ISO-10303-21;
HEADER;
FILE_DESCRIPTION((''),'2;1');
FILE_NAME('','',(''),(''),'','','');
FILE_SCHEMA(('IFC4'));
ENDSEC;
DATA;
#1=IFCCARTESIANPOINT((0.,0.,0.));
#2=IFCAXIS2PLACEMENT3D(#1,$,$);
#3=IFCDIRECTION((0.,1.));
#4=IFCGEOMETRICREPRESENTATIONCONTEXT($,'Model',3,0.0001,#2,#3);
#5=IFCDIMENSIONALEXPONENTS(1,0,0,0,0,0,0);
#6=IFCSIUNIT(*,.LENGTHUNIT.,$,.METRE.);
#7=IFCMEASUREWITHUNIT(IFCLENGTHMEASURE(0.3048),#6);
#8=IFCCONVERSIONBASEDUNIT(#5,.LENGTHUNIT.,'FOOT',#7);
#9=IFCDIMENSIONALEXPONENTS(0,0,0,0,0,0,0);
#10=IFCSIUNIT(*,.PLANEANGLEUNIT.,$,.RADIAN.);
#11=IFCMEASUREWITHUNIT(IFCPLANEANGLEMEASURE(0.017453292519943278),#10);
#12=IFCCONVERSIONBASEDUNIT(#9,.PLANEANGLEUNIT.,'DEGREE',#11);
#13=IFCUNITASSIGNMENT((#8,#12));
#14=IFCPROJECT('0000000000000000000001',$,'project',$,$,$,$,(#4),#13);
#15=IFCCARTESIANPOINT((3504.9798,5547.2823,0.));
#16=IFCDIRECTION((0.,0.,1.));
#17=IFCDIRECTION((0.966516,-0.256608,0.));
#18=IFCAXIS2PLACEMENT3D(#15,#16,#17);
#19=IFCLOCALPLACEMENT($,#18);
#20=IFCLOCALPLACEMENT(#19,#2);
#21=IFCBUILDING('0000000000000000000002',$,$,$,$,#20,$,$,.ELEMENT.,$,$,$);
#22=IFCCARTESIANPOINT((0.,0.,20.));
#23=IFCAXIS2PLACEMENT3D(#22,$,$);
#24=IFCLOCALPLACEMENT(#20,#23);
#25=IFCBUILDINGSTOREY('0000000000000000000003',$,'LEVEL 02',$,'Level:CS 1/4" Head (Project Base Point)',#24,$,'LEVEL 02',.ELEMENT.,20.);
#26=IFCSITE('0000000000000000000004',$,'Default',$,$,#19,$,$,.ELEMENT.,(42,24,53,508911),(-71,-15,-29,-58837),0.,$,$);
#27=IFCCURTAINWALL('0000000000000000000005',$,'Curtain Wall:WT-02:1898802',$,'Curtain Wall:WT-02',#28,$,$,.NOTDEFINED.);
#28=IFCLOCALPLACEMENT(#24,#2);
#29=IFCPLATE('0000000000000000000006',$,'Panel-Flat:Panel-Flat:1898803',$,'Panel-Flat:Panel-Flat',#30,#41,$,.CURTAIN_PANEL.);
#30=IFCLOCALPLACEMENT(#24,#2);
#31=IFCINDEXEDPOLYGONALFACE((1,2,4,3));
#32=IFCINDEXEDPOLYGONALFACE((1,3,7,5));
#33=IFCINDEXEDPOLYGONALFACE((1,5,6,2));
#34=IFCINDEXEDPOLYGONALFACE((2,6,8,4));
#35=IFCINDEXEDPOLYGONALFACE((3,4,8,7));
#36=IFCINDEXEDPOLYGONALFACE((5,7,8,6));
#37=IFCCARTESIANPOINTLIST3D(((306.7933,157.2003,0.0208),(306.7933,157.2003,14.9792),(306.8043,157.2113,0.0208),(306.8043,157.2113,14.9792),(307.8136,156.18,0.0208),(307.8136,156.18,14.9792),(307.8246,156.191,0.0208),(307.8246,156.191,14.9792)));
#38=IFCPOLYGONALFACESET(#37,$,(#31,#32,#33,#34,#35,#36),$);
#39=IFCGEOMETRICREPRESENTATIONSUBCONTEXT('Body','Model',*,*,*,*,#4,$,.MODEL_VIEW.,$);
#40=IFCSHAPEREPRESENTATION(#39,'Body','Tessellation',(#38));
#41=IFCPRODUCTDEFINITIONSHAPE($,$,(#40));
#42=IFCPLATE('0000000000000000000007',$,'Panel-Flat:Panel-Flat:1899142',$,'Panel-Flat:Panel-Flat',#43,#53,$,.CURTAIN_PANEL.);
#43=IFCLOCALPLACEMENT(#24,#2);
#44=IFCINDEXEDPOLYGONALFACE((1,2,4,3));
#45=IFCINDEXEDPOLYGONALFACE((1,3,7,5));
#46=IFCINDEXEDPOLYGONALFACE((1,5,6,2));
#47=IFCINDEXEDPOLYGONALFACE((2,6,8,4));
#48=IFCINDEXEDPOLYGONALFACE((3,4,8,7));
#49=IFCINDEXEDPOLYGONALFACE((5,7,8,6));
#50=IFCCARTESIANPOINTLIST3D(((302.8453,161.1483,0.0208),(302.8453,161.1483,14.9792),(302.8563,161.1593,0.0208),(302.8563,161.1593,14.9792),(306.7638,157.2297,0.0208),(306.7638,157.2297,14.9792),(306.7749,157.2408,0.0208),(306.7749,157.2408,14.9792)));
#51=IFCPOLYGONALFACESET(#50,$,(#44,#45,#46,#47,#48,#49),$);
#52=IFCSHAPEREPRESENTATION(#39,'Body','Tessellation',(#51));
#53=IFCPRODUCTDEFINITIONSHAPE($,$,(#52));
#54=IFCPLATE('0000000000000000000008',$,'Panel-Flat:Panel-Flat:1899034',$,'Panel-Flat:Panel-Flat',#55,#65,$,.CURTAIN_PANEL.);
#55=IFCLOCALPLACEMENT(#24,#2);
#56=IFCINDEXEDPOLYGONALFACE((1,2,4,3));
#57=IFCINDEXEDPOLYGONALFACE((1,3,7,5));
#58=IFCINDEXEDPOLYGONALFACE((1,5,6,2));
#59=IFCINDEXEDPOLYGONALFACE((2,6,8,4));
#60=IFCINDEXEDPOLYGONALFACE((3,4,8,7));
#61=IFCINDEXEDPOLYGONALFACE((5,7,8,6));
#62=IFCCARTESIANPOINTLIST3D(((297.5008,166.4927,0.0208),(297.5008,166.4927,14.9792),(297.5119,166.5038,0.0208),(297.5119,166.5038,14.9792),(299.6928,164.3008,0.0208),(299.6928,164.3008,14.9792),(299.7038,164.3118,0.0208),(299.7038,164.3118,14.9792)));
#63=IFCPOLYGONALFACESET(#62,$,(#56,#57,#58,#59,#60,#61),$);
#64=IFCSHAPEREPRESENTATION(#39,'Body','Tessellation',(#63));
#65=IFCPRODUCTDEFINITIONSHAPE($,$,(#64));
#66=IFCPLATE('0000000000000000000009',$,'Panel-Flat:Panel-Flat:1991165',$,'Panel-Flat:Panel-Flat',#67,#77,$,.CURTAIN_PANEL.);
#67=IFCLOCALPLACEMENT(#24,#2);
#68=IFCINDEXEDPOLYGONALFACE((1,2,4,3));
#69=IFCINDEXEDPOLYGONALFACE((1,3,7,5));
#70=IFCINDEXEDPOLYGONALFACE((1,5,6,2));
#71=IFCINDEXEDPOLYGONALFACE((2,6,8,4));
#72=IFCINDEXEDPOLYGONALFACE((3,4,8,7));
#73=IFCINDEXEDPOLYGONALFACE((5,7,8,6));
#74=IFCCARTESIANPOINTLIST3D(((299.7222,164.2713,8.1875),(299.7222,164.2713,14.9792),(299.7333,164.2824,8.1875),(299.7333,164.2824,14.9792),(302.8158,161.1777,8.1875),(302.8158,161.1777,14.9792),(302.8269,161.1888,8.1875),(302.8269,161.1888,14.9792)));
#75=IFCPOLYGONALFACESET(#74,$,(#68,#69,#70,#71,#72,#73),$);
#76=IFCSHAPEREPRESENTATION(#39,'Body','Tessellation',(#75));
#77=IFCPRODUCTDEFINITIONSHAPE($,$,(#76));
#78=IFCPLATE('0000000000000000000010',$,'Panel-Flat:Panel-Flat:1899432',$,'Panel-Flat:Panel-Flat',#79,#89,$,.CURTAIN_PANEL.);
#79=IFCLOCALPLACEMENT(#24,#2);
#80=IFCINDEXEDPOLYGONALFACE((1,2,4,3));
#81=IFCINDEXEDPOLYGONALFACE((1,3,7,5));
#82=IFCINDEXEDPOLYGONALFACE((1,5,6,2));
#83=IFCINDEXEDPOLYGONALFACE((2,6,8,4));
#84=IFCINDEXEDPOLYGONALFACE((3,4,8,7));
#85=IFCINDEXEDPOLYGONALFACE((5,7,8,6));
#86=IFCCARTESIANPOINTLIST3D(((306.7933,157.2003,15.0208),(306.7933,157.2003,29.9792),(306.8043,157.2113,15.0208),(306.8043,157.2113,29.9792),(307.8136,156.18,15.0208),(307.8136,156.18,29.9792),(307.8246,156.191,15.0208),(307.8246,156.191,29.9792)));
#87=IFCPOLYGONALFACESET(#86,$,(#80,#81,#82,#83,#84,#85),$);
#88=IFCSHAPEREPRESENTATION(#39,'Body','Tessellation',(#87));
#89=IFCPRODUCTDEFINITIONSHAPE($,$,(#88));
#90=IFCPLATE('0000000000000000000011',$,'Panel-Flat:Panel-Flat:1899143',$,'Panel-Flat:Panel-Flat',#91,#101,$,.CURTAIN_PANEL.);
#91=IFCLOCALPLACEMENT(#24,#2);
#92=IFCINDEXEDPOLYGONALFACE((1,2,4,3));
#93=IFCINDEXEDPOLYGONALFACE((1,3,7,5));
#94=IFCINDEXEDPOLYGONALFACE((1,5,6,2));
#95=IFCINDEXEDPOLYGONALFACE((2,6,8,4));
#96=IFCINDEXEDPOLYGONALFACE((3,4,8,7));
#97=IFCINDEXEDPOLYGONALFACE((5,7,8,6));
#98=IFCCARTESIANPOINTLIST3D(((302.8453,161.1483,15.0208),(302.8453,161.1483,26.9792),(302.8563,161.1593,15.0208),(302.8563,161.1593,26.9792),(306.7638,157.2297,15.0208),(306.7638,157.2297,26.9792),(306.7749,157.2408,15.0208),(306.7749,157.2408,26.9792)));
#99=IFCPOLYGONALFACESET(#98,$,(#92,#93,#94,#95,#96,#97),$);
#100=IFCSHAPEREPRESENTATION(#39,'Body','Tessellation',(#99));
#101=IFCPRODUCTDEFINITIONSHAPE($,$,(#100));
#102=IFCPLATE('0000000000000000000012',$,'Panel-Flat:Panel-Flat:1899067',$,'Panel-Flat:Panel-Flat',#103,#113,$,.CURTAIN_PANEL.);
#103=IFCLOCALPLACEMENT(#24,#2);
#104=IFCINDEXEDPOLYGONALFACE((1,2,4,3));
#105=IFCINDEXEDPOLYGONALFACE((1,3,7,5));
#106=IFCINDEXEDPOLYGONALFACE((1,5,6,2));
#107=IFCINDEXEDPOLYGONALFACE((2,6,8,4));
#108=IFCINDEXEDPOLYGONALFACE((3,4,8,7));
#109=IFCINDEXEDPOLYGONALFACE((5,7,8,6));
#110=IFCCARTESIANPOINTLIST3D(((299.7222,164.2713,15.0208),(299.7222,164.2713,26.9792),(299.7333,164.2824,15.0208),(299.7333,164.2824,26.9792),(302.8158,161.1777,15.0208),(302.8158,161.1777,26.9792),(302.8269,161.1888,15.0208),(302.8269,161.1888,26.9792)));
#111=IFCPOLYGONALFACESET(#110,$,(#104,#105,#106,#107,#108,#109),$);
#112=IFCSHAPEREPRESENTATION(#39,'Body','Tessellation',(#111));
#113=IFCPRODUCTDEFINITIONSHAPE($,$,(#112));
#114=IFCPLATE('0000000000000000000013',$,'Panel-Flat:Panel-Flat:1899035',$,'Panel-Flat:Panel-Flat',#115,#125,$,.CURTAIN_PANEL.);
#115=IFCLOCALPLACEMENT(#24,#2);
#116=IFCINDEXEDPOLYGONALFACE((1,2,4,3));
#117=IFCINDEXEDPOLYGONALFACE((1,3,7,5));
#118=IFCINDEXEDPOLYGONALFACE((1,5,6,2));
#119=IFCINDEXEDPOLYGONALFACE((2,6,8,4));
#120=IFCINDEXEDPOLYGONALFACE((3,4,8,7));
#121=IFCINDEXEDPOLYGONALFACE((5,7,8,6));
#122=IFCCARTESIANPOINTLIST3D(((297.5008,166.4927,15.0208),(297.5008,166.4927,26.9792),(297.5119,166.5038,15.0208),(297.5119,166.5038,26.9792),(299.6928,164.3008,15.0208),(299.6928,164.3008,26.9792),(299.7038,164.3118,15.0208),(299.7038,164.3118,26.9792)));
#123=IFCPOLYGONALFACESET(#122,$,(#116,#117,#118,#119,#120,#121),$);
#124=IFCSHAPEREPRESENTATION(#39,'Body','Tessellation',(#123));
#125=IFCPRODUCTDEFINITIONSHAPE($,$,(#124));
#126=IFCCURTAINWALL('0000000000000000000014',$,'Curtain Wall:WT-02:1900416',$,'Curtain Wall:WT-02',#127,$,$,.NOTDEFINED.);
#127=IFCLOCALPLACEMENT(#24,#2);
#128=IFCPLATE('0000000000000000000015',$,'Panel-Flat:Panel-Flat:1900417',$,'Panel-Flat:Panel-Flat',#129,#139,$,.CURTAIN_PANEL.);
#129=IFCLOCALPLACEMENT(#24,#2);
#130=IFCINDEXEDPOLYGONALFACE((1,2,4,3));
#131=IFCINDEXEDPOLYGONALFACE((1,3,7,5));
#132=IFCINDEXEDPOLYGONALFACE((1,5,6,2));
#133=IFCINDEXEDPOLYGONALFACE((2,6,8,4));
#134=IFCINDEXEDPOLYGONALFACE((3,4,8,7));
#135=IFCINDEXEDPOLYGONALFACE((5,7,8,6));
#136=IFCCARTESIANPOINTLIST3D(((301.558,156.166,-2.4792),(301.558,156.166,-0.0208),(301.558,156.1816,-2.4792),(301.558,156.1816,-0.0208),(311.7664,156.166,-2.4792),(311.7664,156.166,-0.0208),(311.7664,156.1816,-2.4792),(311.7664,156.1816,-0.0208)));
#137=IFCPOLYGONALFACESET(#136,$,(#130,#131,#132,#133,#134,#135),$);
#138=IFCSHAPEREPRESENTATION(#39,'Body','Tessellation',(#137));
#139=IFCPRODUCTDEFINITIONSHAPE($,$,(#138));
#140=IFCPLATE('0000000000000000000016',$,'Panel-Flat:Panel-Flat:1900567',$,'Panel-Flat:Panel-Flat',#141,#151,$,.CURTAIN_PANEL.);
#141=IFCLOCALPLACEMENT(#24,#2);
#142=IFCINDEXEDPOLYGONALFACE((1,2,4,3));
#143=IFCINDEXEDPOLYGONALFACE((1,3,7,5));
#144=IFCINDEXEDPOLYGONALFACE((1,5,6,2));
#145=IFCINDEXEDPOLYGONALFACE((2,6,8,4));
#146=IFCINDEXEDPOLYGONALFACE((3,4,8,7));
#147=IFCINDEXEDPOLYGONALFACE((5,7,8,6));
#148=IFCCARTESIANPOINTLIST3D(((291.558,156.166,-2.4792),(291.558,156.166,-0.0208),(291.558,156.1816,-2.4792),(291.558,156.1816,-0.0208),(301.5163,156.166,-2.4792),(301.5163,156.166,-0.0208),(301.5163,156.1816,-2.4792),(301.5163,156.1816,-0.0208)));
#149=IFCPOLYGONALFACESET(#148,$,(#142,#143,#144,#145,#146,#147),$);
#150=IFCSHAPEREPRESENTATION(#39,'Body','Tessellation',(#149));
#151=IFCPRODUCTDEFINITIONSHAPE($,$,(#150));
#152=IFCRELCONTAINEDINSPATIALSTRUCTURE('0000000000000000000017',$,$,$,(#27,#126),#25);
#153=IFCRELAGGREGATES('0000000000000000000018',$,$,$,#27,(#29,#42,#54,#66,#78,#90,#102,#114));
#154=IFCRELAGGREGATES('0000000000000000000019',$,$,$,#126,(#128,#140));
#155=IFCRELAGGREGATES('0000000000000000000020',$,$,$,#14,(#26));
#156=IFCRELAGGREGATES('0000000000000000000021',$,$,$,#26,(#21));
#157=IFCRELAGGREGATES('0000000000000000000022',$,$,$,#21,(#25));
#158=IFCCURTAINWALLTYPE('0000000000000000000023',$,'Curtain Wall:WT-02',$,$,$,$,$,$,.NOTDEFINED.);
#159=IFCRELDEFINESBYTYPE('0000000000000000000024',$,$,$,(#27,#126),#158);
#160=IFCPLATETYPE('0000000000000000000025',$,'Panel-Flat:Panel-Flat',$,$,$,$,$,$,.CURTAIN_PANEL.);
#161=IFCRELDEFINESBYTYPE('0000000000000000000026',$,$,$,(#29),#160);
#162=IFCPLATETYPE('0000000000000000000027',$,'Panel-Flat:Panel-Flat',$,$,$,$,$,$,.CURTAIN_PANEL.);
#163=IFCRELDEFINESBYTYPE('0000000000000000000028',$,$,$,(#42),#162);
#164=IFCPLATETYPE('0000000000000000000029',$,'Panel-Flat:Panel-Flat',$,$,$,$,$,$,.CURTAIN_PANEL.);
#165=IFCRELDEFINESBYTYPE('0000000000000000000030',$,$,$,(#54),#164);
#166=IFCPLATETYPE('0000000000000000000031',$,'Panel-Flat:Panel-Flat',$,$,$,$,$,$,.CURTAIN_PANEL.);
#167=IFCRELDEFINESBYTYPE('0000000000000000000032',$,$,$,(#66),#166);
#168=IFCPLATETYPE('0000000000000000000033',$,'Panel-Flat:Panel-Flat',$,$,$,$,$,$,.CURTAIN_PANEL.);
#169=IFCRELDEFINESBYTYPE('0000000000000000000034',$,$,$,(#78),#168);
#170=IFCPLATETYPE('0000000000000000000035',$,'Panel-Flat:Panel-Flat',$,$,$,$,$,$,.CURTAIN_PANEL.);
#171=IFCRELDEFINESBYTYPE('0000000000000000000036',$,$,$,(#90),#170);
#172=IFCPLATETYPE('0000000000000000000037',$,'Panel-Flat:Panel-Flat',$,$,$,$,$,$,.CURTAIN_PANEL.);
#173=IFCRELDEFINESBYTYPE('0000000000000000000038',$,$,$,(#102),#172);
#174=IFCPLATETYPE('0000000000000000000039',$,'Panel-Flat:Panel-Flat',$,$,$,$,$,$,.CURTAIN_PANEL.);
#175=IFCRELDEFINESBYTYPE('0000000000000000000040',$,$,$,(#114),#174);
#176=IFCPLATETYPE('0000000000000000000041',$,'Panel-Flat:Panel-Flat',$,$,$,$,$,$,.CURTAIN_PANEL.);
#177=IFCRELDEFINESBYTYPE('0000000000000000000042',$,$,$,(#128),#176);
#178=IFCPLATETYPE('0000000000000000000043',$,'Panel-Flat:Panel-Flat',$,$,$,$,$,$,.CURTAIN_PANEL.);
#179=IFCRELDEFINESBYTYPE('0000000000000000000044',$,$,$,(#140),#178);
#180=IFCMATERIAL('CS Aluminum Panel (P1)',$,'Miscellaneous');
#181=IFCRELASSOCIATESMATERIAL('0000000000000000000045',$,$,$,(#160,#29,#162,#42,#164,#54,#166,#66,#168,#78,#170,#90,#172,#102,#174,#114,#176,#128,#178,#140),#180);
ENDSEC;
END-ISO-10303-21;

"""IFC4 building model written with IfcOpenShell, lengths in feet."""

from ifc_helpers import new_model, entity, si_unit, converted_unit, direction, frame, origin, place, context, subcontext, project, spatial, indexed_curve, outline, extrude, source, transform, mapped, material, type_object, type_shapes, element, aggregate, save


model = new_model("IFC4")

# Units and contexts
model_context = context("Model", 3, precision=0.0001, world=origin(), true_north=direction((0.0, 1.0)))
body_context = subcontext(model_context, "Body", "Model", "MODEL_VIEW")
ifc_project = project(units=[converted_unit("LENGTHUNIT", "FOOT", entity("IfcLengthMeasure", 0.3048), si_unit("LENGTHUNIT", "METRE"), dimensions=[1, 0, 0, 0, 0, 0, 0]), converted_unit("PLANEANGLEUNIT", "DEGREE", entity("IfcPlaneAngleMeasure", 0.017453292519943278), si_unit("PLANEANGLEUNIT", "RADIAN"), dimensions=[0, 0, 0, 0, 0, 0, 0])], contexts=[model_context])

# Site, building, storey
site_placement = place(None, frame((3504.9798, 5547.2823, 0.0), z_axis=(0.0, 0.0, 1.0), x_axis=(0.966516, -0.256608, 0.0)))
site = spatial("IfcSite", under=ifc_project, at=site_placement, Name="Default", CompositionType="ELEMENT", RefLatitude=(42, 24, 53, 508911), RefLongitude=(-71, -15, -29, -58837), RefElevation=0.0)
building_placement = place(site_placement, origin())
building = spatial("IfcBuilding", under=site, at=building_placement, CompositionType="ELEMENT")
storey_placement = place(building_placement, frame((0.0, 0.0, 20.0)))
storey = spatial("IfcBuildingStorey", under=building, at=storey_placement, Name="LEVEL 02", ObjectType="Level:CS 1/4\" Head (Project Base Point)", LongName="LEVEL 02", CompositionType="ELEMENT", Elevation=20.0)

# Curtain walls, plates
curtain_wall_type_1 = type_object("IfcCurtainWallType", Name="Curtain Wall:WT-02", PredefinedType="NOTDEFINED")
curtain_wall_1_placement = place(storey_placement, frame((0.0, 0.0, -20.0)))
curtain_wall_1 = element("IfcCurtainWall", 1, at=curtain_wall_1_placement, inside=storey, type_object=curtain_wall_type_1, Name="Curtain Wall:WT-02:1898802", ObjectType="Curtain Wall:WT-02", PredefinedType="NOTDEFINED")
ifc_material_1 = material(Name="CS Aluminum Panel (P1)", Category="Miscellaneous")
plate_type_1 = type_object("IfcPlateType", Name="Panel-Flat:Panel-Flat", PredefinedType="CURTAIN_PANEL", material=ifc_material_1)
shared_shape_1 = source(origin(), body_context, "Body", "SweptSolid", [
    extrude(outline(indexed_curve([(-0.0078, -0.7214), (0.0078, -0.7214), (0.0078, 0.7214), (-0.0078, 0.7214), (-0.0078, -0.7214)], self_intersect=False)), frame((0.7214, 0.0078, 0.0), z_axis=(0.0, 0.0, 1.0), x_axis=(0.0, -1.0, 0.0)), (0.0, 0.0, 1.0), 14.9583),
])
type_shapes(plate_type_1, [shared_shape_1])
plate_1_placement = place(curtain_wall_1_placement, frame((307.8246, 156.191, 20.0208), z_axis=(0.0, 0.0, 1.0), x_axis=(-0.707107, 0.707107, 0.0)))
plate_1 = element("IfcPlate", 2, at=plate_1_placement, type_object=plate_type_1, material=ifc_material_1, Name="Panel-Flat:Panel-Flat:1898803", ObjectType="Panel-Flat:Panel-Flat", PredefinedType="CURTAIN_PANEL", context=body_context, shape_type="MappedRepresentation", body=[
    mapped(shared_shape_1, transform((0.0, 0.0, 0.0), scale=1.0)),
])
plate_type_2 = type_object("IfcPlateType", Name="Panel-Flat:Panel-Flat", PredefinedType="CURTAIN_PANEL", material=ifc_material_1)
shared_shape_2 = source(origin(), body_context, "Body", "SweptSolid", [
    extrude(outline(indexed_curve([(-0.0078, -2.7708), (0.0078, -2.7708), (0.0078, 2.7708), (-0.0078, 2.7708), (-0.0078, -2.7708)], self_intersect=False)), frame((2.7708, 0.0078, 0.0), z_axis=(0.0, 0.0, 1.0), x_axis=(0.0, -1.0, 0.0)), (0.0, 0.0, 1.0), 14.9583),
])
type_shapes(plate_type_2, [shared_shape_2])
plate_2_placement = place(curtain_wall_1_placement, frame((306.7749, 157.2408, 20.0208), z_axis=(0.0, 0.0, 1.0), x_axis=(-0.707107, 0.707107, 0.0)))
plate_2 = element("IfcPlate", 3, at=plate_2_placement, type_object=plate_type_2, material=ifc_material_1, Name="Panel-Flat:Panel-Flat:1899142", ObjectType="Panel-Flat:Panel-Flat", PredefinedType="CURTAIN_PANEL", context=body_context, shape_type="MappedRepresentation", body=[
    mapped(shared_shape_2, transform((0.0, 0.0, 0.0), scale=1.0)),
])
plate_type_3 = type_object("IfcPlateType", Name="Panel-Flat:Panel-Flat", PredefinedType="CURTAIN_PANEL", material=ifc_material_1)
shared_shape_3 = source(origin(), body_context, "Body", "SweptSolid", [
    extrude(outline(indexed_curve([(-0.0078, -1.5499), (0.0078, -1.5499), (0.0078, 1.5499), (-0.0078, 1.5499), (-0.0078, -1.5499)], self_intersect=False)), frame((1.5499, 0.0078, 0.0), z_axis=(0.0, 0.0, 1.0), x_axis=(0.0, -1.0, 0.0)), (0.0, 0.0, 1.0), 14.9583),
])
type_shapes(plate_type_3, [shared_shape_3])
plate_3_placement = place(curtain_wall_1_placement, frame((299.7038, 164.3118, 20.0208), z_axis=(0.0, 0.0, 1.0), x_axis=(-0.707107, 0.707107, 0.0)))
plate_3 = element("IfcPlate", 4, at=plate_3_placement, type_object=plate_type_3, material=ifc_material_1, Name="Panel-Flat:Panel-Flat:1899034", ObjectType="Panel-Flat:Panel-Flat", PredefinedType="CURTAIN_PANEL", context=body_context, shape_type="MappedRepresentation", body=[
    mapped(shared_shape_3, transform((0.0, 0.0, 0.0), scale=1.0)),
])
plate_type_4 = type_object("IfcPlateType", Name="Panel-Flat:Panel-Flat", PredefinedType="CURTAIN_PANEL", material=ifc_material_1)
shared_shape_4 = source(origin(), body_context, "Body", "SweptSolid", [
    extrude(outline(indexed_curve([(-0.0078, -2.1875), (0.0078, -2.1875), (0.0078, 2.1875), (-0.0078, 2.1875), (-0.0078, -2.1875)], self_intersect=False)), frame((2.1875, 0.0078, 0.0), z_axis=(0.0, 0.0, 1.0), x_axis=(0.0, -1.0, 0.0)), (0.0, 0.0, 1.0), 6.7917),
])
type_shapes(plate_type_4, [shared_shape_4])
plate_4_placement = place(curtain_wall_1_placement, frame((302.8269, 161.1888, 28.1875), z_axis=(0.0, 0.0, 1.0), x_axis=(-0.707107, 0.707107, 0.0)))
plate_4 = element("IfcPlate", 5, at=plate_4_placement, type_object=plate_type_4, material=ifc_material_1, Name="Panel-Flat:Panel-Flat:1991165", ObjectType="Panel-Flat:Panel-Flat", PredefinedType="CURTAIN_PANEL", context=body_context, shape_type="MappedRepresentation", body=[
    mapped(shared_shape_4, transform((0.0, 0.0, 0.0), scale=1.0)),
])
plate_type_5 = type_object("IfcPlateType", Name="Panel-Flat:Panel-Flat", PredefinedType="CURTAIN_PANEL", material=ifc_material_1)
shared_shape_5 = source(origin(), body_context, "Body", "SweptSolid", [
    extrude(outline(indexed_curve([(-0.0078, -0.7214), (0.0078, -0.7214), (0.0078, 0.7214), (-0.0078, 0.7214), (-0.0078, -0.7214)], self_intersect=False)), frame((0.7214, 0.0078, 0.0), z_axis=(0.0, 0.0, 1.0), x_axis=(0.0, -1.0, 0.0)), (0.0, 0.0, 1.0), 14.9583),
])
type_shapes(plate_type_5, [shared_shape_5])
plate_5_placement = place(curtain_wall_1_placement, frame((307.8246, 156.191, 35.0208), z_axis=(0.0, 0.0, 1.0), x_axis=(-0.707107, 0.707107, 0.0)))
plate_5 = element("IfcPlate", 6, at=plate_5_placement, type_object=plate_type_5, material=ifc_material_1, Name="Panel-Flat:Panel-Flat:1899432", ObjectType="Panel-Flat:Panel-Flat", PredefinedType="CURTAIN_PANEL", context=body_context, shape_type="MappedRepresentation", body=[
    mapped(shared_shape_5, transform((0.0, 0.0, 0.0), scale=1.0)),
])
plate_type_6 = type_object("IfcPlateType", Name="Panel-Flat:Panel-Flat", PredefinedType="CURTAIN_PANEL", material=ifc_material_1)
shared_shape_6 = source(origin(), body_context, "Body", "SweptSolid", [
    extrude(outline(indexed_curve([(-0.0078, -2.7708), (0.0078, -2.7708), (0.0078, 2.7708), (-0.0078, 2.7708), (-0.0078, -2.7708)], self_intersect=False)), frame((2.7708, 0.0078, 0.0), z_axis=(0.0, 0.0, 1.0), x_axis=(0.0, -1.0, 0.0)), (0.0, 0.0, 1.0), 11.9583),
])
type_shapes(plate_type_6, [shared_shape_6])
plate_6_placement = place(curtain_wall_1_placement, frame((306.7749, 157.2408, 35.0208), z_axis=(0.0, 0.0, 1.0), x_axis=(-0.707107, 0.707107, 0.0)))
plate_6 = element("IfcPlate", 7, at=plate_6_placement, type_object=plate_type_6, material=ifc_material_1, Name="Panel-Flat:Panel-Flat:1899143", ObjectType="Panel-Flat:Panel-Flat", PredefinedType="CURTAIN_PANEL", context=body_context, shape_type="MappedRepresentation", body=[
    mapped(shared_shape_6, transform((0.0, 0.0, 0.0), scale=1.0)),
])
plate_type_7 = type_object("IfcPlateType", Name="Panel-Flat:Panel-Flat", PredefinedType="CURTAIN_PANEL", material=ifc_material_1)
shared_shape_7 = source(origin(), body_context, "Body", "SweptSolid", [
    extrude(outline(indexed_curve([(-0.0078, -2.1875), (0.0078, -2.1875), (0.0078, 2.1875), (-0.0078, 2.1875), (-0.0078, -2.1875)], self_intersect=False)), frame((2.1875, 0.0078, 0.0), z_axis=(0.0, 0.0, 1.0), x_axis=(0.0, -1.0, 0.0)), (0.0, 0.0, 1.0), 11.9583),
])
type_shapes(plate_type_7, [shared_shape_7])
plate_7_placement = place(curtain_wall_1_placement, frame((302.8269, 161.1888, 35.0208), z_axis=(0.0, 0.0, 1.0), x_axis=(-0.707107, 0.707107, 0.0)))
plate_7 = element("IfcPlate", 8, at=plate_7_placement, type_object=plate_type_7, material=ifc_material_1, Name="Panel-Flat:Panel-Flat:1899067", ObjectType="Panel-Flat:Panel-Flat", PredefinedType="CURTAIN_PANEL", context=body_context, shape_type="MappedRepresentation", body=[
    mapped(shared_shape_7, transform((0.0, 0.0, 0.0), scale=1.0)),
])
plate_type_8 = type_object("IfcPlateType", Name="Panel-Flat:Panel-Flat", PredefinedType="CURTAIN_PANEL", material=ifc_material_1)
shared_shape_8 = source(origin(), body_context, "Body", "SweptSolid", [
    extrude(outline(indexed_curve([(-0.0078, -1.5499), (0.0078, -1.5499), (0.0078, 1.5499), (-0.0078, 1.5499), (-0.0078, -1.5499)], self_intersect=False)), frame((1.5499, 0.0078, 0.0), z_axis=(0.0, 0.0, 1.0), x_axis=(0.0, -1.0, 0.0)), (0.0, 0.0, 1.0), 11.9583),
])
type_shapes(plate_type_8, [shared_shape_8])
plate_8_placement = place(curtain_wall_1_placement, frame((299.7038, 164.3118, 35.0208), z_axis=(0.0, 0.0, 1.0), x_axis=(-0.707107, 0.707107, 0.0)))
plate_8 = element("IfcPlate", 9, at=plate_8_placement, type_object=plate_type_8, material=ifc_material_1, Name="Panel-Flat:Panel-Flat:1899035", ObjectType="Panel-Flat:Panel-Flat", PredefinedType="CURTAIN_PANEL", context=body_context, shape_type="MappedRepresentation", body=[
    mapped(shared_shape_8, transform((0.0, 0.0, 0.0), scale=1.0)),
])
aggregate(curtain_wall_1, [plate_1, plate_2, plate_3, plate_4, plate_5, plate_6, plate_7, plate_8])
curtain_wall_2_placement = place(storey_placement, frame((0.0, 0.0, -20.0)))
curtain_wall_2 = element("IfcCurtainWall", 10, at=curtain_wall_2_placement, inside=storey, type_object=curtain_wall_type_1, Name="Curtain Wall:WT-02:1900416", ObjectType="Curtain Wall:WT-02", PredefinedType="NOTDEFINED")
plate_type_9 = type_object("IfcPlateType", Name="Panel-Flat:Panel-Flat", PredefinedType="CURTAIN_PANEL", material=ifc_material_1)
shared_shape_9 = source(origin(), body_context, "Body", "SweptSolid", [
    extrude(outline(indexed_curve([(-0.0078, -5.1042), (0.0078, -5.1042), (0.0078, 5.1042), (-0.0078, 5.1042), (-0.0078, -5.1042)], self_intersect=False)), frame((5.1042, 0.0078, 0.0), z_axis=(0.0, 0.0, 1.0), x_axis=(0.0, -1.0, 0.0)), (0.0, 0.0, 1.0), 2.4583),
])
type_shapes(plate_type_9, [shared_shape_9])
plate_9_placement = place(curtain_wall_2_placement, frame((311.7664, 156.1816, 17.5208), z_axis=(0.0, 0.0, 1.0), x_axis=(-1.0, 0.0, 0.0)))
plate_9 = element("IfcPlate", 11, at=plate_9_placement, type_object=plate_type_9, material=ifc_material_1, Name="Panel-Flat:Panel-Flat:1900417", ObjectType="Panel-Flat:Panel-Flat", PredefinedType="CURTAIN_PANEL", context=body_context, shape_type="MappedRepresentation", body=[
    mapped(shared_shape_9, transform((0.0, 0.0, 0.0), scale=1.0)),
])
plate_type_10 = type_object("IfcPlateType", Name="Panel-Flat:Panel-Flat", PredefinedType="CURTAIN_PANEL", material=ifc_material_1)
shared_shape_10 = source(origin(), body_context, "Body", "SweptSolid", [
    extrude(outline(indexed_curve([(-0.0078, -4.9792), (0.0078, -4.9792), (0.0078, 4.9792), (-0.0078, 4.9792), (-0.0078, -4.9792)], self_intersect=False)), frame((4.9792, 0.0078, 0.0), z_axis=(0.0, 0.0, 1.0), x_axis=(0.0, -1.0, 0.0)), (0.0, 0.0, 1.0), 2.4583),
])
type_shapes(plate_type_10, [shared_shape_10])
plate_10_placement = place(curtain_wall_2_placement, frame((301.5163, 156.1816, 17.5208), z_axis=(0.0, 0.0, 1.0), x_axis=(-1.0, 0.0, 0.0)))
plate_10 = element("IfcPlate", 12, at=plate_10_placement, type_object=plate_type_10, material=ifc_material_1, Name="Panel-Flat:Panel-Flat:1900567", ObjectType="Panel-Flat:Panel-Flat", PredefinedType="CURTAIN_PANEL", context=body_context, shape_type="MappedRepresentation", body=[
    mapped(shared_shape_10, transform((0.0, 0.0, 0.0), scale=1.0)),
])
aggregate(curtain_wall_2, [plate_9, plate_10])

save(model, "model.ifc")
